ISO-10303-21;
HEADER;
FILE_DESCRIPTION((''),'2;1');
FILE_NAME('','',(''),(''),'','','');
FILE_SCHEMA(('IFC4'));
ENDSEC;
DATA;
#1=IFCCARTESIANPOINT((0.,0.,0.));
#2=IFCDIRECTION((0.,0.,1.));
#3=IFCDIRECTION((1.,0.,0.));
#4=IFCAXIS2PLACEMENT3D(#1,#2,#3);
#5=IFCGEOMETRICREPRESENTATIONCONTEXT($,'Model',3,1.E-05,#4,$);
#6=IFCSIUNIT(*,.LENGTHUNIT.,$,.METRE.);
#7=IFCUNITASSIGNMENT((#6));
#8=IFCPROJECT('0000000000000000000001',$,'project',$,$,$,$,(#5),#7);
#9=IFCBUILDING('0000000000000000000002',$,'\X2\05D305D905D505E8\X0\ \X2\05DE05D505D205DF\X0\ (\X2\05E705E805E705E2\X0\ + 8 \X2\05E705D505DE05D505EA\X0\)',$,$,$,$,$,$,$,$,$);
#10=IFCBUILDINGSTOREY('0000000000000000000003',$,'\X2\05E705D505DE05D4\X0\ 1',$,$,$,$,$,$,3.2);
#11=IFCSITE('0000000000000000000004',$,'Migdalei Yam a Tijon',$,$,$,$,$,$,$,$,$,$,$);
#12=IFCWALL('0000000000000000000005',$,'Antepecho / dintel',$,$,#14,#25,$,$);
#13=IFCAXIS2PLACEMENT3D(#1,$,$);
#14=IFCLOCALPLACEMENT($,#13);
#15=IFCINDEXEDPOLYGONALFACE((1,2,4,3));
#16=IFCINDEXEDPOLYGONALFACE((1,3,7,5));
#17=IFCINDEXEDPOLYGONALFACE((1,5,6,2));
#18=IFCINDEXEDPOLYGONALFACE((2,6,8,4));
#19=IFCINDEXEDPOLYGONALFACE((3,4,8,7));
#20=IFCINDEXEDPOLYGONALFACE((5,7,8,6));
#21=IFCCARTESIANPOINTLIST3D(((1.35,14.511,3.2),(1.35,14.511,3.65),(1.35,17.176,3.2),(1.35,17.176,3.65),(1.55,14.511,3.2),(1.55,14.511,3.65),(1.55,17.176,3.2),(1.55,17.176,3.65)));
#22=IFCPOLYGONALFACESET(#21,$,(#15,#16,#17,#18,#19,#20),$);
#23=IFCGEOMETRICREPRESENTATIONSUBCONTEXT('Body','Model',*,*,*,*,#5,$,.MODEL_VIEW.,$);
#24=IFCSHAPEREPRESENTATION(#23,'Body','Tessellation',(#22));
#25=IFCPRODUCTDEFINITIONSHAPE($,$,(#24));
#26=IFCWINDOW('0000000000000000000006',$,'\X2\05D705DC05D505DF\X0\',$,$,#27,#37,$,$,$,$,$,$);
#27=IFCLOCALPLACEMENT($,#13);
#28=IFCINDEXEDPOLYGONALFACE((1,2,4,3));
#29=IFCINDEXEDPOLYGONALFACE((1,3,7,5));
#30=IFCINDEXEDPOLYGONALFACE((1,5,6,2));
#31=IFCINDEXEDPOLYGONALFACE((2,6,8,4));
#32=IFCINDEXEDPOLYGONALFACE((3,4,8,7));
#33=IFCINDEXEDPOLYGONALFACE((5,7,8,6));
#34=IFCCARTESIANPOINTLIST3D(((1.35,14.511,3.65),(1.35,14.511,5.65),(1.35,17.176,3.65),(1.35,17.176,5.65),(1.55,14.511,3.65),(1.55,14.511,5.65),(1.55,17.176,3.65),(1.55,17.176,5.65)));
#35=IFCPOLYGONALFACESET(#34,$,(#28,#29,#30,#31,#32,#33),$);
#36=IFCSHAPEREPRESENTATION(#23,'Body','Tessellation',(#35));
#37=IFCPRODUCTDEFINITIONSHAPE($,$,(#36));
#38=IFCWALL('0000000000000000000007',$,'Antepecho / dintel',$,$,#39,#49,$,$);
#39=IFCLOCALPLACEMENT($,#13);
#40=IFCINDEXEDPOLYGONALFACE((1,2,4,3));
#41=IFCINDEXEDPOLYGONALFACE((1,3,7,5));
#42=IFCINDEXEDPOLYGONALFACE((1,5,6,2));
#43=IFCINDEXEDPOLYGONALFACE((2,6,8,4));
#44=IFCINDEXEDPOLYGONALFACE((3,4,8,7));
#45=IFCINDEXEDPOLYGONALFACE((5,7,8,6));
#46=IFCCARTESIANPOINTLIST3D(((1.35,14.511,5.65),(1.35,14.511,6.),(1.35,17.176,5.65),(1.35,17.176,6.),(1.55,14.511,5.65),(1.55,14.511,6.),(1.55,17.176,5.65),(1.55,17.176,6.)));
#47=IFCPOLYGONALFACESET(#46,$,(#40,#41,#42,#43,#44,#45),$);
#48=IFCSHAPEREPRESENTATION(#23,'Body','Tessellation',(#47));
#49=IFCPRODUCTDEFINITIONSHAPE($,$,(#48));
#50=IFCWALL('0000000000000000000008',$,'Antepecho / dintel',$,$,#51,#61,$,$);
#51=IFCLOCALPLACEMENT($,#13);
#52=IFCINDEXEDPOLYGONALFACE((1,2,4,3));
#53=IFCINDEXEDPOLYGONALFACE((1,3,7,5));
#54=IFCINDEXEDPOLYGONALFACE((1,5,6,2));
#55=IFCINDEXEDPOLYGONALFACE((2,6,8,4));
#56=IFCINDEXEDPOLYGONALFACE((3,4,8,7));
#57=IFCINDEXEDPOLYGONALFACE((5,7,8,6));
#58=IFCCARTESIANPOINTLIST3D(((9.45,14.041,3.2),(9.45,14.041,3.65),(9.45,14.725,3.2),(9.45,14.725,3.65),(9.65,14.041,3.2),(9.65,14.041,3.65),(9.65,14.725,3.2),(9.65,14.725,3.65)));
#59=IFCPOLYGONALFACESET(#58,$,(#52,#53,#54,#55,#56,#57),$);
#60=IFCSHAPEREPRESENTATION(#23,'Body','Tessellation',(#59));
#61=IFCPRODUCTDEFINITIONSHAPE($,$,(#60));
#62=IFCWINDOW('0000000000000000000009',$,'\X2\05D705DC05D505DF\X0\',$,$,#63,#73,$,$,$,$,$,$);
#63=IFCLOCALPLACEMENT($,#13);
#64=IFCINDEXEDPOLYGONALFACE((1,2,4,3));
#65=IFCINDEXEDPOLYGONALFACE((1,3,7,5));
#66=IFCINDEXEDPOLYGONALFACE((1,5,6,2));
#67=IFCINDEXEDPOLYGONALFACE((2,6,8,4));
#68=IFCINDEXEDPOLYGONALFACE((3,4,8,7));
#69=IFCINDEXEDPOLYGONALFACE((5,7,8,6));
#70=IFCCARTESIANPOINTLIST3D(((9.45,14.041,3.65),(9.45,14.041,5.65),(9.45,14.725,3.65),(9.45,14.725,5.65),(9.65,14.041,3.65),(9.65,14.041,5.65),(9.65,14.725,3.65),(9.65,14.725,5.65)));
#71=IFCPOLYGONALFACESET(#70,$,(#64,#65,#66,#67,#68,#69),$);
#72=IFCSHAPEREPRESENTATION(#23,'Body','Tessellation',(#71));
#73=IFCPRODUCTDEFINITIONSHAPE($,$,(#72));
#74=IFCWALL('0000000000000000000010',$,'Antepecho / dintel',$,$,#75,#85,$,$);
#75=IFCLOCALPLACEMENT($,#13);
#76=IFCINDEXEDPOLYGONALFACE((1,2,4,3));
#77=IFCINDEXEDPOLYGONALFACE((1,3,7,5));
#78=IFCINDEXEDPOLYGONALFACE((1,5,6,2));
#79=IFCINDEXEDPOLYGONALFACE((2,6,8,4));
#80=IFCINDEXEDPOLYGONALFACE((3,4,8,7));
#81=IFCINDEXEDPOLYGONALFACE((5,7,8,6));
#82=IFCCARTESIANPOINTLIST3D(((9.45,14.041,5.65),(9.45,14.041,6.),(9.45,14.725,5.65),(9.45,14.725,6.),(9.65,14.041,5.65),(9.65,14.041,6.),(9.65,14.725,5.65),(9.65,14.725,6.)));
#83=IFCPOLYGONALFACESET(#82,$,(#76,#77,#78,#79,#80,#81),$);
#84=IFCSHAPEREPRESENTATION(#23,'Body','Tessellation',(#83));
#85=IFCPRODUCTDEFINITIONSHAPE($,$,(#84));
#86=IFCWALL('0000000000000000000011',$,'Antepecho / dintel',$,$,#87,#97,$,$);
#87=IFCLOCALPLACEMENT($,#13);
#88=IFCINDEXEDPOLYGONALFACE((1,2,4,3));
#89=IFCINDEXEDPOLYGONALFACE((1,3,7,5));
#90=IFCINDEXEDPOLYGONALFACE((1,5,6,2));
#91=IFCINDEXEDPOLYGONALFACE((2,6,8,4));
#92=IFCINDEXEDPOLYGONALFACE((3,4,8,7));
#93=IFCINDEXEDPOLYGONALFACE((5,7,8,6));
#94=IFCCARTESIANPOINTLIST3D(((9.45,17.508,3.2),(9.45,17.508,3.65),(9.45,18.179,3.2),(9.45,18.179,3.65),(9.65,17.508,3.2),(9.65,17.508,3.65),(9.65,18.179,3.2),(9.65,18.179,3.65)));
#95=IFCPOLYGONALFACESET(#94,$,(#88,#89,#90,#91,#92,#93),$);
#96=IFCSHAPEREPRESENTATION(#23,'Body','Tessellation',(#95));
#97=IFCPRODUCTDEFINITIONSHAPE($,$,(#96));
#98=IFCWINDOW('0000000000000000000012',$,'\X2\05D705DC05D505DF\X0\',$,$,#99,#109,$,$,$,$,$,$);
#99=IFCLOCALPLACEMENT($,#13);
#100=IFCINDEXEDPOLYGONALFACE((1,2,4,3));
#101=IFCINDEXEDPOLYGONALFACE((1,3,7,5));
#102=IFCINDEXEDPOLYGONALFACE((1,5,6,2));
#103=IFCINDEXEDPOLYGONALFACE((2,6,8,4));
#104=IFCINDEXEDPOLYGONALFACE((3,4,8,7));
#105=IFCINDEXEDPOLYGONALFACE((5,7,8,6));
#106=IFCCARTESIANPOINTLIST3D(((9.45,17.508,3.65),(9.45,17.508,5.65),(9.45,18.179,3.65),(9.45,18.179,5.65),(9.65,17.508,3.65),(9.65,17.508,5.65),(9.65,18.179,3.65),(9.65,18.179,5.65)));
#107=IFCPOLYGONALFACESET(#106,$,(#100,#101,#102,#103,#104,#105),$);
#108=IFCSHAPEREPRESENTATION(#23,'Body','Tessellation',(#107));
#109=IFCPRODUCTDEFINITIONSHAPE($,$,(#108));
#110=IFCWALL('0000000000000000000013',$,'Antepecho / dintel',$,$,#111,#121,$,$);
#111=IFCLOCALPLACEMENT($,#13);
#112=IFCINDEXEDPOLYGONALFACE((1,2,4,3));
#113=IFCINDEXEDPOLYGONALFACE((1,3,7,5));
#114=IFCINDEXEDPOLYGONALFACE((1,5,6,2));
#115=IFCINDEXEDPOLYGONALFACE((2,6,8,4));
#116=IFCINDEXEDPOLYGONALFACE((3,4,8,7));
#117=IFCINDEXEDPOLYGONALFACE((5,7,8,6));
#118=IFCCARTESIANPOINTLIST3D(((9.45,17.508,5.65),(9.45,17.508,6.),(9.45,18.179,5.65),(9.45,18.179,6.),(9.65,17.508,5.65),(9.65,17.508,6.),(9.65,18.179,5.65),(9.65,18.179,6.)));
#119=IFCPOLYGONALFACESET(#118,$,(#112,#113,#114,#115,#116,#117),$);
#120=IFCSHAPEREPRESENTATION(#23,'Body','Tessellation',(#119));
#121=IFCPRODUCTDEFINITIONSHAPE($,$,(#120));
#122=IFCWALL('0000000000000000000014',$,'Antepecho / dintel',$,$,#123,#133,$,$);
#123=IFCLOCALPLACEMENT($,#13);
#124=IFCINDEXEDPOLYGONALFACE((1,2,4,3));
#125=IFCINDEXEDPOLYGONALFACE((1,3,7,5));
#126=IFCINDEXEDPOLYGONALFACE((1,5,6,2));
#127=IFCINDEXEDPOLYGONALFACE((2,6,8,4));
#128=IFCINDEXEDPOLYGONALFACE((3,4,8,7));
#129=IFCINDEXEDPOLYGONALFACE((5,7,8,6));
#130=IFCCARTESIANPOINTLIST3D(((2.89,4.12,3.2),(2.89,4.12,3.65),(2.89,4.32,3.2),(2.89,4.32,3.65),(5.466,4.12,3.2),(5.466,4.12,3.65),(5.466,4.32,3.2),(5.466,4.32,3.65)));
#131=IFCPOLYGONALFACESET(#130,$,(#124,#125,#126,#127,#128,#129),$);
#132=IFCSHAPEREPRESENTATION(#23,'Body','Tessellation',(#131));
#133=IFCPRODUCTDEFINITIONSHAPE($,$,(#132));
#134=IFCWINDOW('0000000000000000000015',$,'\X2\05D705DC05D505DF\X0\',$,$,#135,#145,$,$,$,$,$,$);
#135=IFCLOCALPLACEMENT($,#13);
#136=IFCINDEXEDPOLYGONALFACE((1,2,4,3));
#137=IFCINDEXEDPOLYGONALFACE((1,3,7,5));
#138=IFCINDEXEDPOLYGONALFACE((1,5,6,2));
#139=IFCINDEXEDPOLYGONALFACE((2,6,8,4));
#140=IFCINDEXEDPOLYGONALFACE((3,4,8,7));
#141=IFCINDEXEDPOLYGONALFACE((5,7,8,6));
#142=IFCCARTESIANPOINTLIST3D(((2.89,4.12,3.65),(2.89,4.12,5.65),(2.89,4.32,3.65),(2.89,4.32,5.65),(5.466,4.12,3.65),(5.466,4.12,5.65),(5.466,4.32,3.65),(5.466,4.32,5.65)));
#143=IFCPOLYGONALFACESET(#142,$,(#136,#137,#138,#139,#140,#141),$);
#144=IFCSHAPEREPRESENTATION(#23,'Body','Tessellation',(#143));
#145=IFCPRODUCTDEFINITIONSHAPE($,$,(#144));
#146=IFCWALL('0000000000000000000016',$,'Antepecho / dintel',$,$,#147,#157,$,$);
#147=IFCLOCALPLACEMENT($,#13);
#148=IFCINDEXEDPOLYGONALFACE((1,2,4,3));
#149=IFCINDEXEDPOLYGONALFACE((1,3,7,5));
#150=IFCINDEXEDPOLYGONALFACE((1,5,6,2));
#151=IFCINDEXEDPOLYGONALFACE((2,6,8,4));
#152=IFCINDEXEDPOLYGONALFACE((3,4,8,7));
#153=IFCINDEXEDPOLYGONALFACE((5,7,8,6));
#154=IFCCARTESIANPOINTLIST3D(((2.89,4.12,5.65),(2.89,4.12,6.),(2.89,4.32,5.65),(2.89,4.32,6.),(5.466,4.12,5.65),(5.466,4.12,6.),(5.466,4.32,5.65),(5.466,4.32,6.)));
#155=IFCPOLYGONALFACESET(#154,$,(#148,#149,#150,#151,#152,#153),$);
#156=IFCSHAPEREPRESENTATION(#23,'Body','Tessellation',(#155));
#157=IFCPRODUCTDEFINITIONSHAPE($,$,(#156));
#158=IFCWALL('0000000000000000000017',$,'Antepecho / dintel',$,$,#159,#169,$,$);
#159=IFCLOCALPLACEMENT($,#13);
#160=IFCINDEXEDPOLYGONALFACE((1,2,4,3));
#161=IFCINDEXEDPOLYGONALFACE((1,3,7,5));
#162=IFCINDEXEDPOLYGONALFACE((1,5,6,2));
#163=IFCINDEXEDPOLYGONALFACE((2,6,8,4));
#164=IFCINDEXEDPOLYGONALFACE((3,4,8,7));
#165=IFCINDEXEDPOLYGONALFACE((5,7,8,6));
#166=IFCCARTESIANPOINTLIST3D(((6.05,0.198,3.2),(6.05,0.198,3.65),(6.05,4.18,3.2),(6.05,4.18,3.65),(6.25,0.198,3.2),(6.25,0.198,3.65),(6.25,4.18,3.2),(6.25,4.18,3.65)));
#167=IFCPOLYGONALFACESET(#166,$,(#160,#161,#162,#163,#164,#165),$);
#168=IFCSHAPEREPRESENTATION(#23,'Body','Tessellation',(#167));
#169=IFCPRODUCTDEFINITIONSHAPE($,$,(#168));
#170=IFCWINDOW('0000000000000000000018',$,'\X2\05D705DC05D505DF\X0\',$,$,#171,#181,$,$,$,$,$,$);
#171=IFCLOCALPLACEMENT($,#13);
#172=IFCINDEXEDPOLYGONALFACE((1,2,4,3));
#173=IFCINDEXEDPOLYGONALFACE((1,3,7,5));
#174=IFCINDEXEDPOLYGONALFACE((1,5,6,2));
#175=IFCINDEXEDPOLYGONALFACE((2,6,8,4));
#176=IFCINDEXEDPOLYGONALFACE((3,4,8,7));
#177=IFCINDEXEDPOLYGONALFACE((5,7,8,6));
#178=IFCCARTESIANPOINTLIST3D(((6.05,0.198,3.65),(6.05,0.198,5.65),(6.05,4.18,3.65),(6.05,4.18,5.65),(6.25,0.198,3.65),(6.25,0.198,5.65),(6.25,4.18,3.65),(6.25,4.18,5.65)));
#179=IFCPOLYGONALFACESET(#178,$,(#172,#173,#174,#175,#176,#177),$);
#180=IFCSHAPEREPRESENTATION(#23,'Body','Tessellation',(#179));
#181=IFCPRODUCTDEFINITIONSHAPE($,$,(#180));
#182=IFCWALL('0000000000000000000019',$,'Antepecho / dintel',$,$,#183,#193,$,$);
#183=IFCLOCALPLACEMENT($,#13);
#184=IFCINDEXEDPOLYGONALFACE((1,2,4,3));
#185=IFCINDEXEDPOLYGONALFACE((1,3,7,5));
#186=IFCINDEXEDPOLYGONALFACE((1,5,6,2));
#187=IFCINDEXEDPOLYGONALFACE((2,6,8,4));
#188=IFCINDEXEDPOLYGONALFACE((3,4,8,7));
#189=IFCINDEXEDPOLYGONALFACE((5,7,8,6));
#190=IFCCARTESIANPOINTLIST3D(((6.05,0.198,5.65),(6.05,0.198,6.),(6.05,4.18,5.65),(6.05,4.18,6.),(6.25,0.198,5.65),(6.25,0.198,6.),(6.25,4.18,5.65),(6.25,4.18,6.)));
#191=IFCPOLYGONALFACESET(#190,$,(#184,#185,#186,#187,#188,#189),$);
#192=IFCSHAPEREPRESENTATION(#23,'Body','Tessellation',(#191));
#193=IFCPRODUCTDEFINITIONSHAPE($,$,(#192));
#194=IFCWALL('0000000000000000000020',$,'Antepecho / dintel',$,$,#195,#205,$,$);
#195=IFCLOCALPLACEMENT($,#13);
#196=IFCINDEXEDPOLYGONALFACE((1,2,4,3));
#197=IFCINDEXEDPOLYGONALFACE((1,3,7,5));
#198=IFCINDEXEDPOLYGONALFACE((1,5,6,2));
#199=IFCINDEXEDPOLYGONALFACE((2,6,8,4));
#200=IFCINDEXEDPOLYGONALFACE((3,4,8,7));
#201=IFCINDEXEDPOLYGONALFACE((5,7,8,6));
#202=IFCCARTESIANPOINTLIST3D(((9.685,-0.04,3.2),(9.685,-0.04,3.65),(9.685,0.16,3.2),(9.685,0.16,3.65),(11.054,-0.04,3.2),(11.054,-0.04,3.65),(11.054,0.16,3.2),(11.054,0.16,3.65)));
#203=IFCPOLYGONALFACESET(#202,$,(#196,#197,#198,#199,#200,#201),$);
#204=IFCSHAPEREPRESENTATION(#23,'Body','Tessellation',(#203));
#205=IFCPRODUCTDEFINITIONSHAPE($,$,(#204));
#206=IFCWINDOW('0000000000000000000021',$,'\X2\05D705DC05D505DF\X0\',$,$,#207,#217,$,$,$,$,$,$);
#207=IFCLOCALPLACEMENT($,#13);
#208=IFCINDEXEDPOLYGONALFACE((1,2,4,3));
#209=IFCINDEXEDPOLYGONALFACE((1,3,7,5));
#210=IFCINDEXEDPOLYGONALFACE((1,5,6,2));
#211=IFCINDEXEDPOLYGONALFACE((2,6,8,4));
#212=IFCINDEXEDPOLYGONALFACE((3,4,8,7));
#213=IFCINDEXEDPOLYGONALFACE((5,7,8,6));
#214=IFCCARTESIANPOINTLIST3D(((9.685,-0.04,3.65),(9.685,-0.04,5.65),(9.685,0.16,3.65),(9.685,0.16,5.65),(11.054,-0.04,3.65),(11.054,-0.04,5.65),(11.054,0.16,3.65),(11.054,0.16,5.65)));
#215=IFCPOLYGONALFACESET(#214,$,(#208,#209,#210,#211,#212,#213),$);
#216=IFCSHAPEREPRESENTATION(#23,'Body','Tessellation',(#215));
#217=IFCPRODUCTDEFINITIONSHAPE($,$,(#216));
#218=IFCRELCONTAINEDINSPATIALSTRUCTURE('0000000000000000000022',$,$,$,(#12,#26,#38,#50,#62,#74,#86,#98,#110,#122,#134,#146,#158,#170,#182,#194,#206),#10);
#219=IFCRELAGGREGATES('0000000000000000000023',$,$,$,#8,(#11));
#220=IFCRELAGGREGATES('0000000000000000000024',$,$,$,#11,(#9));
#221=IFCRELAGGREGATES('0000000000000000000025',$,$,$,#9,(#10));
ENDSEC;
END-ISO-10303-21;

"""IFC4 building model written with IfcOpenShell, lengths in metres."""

from ifc_helpers import new_model, si_unit, frame, origin_with_axes, context, subcontext, project, spatial, line, indexed_curve, outline, extrude, element, save


model = new_model("IFC4")

# Units and contexts
model_context = context("Model", 3, precision=1e-05, world=origin_with_axes())
body_context = subcontext(model_context, "Body", "Model", "MODEL_VIEW")
ifc_project = project(units=[si_unit("LENGTHUNIT", "METRE")], contexts=[model_context])

# Site, building, storey
site = spatial("IfcSite", under=ifc_project, Name="Migdalei Yam a Tijon")
building = spatial("IfcBuilding", under=site, Name="דיור מוגן (קרקע + 8 קומות)")
storey = spatial("IfcBuildingStorey", under=building, Name="קומה 1", Elevation=3.2)

# Wall
element("IfcWall", 1, inside=storey, Name="Antepecho / dintel", context=body_context, shape_type="SweptSolid", body=[
    extrude(outline(indexed_curve([(0.0, 0.0), (0.2, 0.0), (0.2, 2.665), (0.0, 2.665)], segments=[line(1, 2, 3, 4, 1)])), frame((1.35, 14.511, 3.2), z_axis=(0.0, 0.0, 1.0), x_axis=(1.0, 0.0, 0.0)), (0.0, 0.0, 1.0), 0.45),
])

# Window
element("IfcWindow", 2, inside=storey, Name="חלון", context=body_context, shape_type="SweptSolid", body=[
    extrude(outline(indexed_curve([(0.0, 0.0), (0.2, 0.0), (0.2, 2.665), (0.0, 2.665)], segments=[line(1, 2, 3, 4, 1)])), frame((1.35, 14.511, 3.65), z_axis=(0.0, 0.0, 1.0), x_axis=(1.0, 0.0, 0.0)), (0.0, 0.0, 1.0), 2.0),
])

# Walls
element("IfcWall", 3, inside=storey, Name="Antepecho / dintel", context=body_context, shape_type="SweptSolid", body=[
    extrude(outline(indexed_curve([(0.0, 0.0), (0.2, 0.0), (0.2, 2.665), (0.0, 2.665)], segments=[line(1, 2, 3, 4, 1)])), frame((1.35, 14.511, 5.65), z_axis=(0.0, 0.0, 1.0), x_axis=(1.0, 0.0, 0.0)), (0.0, 0.0, 1.0), 0.35),
])
element("IfcWall", 4, inside=storey, Name="Antepecho / dintel", context=body_context, shape_type="SweptSolid", body=[
    extrude(outline(indexed_curve([(0.0, 0.0), (0.2, 0.0), (0.2, 0.684), (0.0, 0.684)], segments=[line(1, 2, 3, 4, 1)])), frame((9.45, 14.041, 3.2), z_axis=(0.0, 0.0, 1.0), x_axis=(1.0, 0.0, 0.0)), (0.0, 0.0, 1.0), 0.45),
])

# Window
element("IfcWindow", 5, inside=storey, Name="חלון", context=body_context, shape_type="SweptSolid", body=[
    extrude(outline(indexed_curve([(0.0, 0.0), (0.2, 0.0), (0.2, 0.684), (0.0, 0.684)], segments=[line(1, 2, 3, 4, 1)])), frame((9.45, 14.041, 3.65), z_axis=(0.0, 0.0, 1.0), x_axis=(1.0, 0.0, 0.0)), (0.0, 0.0, 1.0), 2.0),
])

# Walls
element("IfcWall", 6, inside=storey, Name="Antepecho / dintel", context=body_context, shape_type="SweptSolid", body=[
    extrude(outline(indexed_curve([(0.0, 0.0), (0.2, 0.0), (0.2, 0.684), (0.0, 0.684)], segments=[line(1, 2, 3, 4, 1)])), frame((9.45, 14.041, 5.65), z_axis=(0.0, 0.0, 1.0), x_axis=(1.0, 0.0, 0.0)), (0.0, 0.0, 1.0), 0.35),
])
element("IfcWall", 7, inside=storey, Name="Antepecho / dintel", context=body_context, shape_type="SweptSolid", body=[
    extrude(outline(indexed_curve([(0.0, 0.0), (0.2, 0.0), (0.2, 0.671), (0.0, 0.671)], segments=[line(1, 2, 3, 4, 1)])), frame((9.45, 17.508, 3.2), z_axis=(0.0, 0.0, 1.0), x_axis=(1.0, 0.0, 0.0)), (0.0, 0.0, 1.0), 0.45),
])

# Window
element("IfcWindow", 8, inside=storey, Name="חלון", context=body_context, shape_type="SweptSolid", body=[
    extrude(outline(indexed_curve([(0.0, 0.0), (0.2, 0.0), (0.2, 0.671), (0.0, 0.671)], segments=[line(1, 2, 3, 4, 1)])), frame((9.45, 17.508, 3.65), z_axis=(0.0, 0.0, 1.0), x_axis=(1.0, 0.0, 0.0)), (0.0, 0.0, 1.0), 2.0),
])

# Walls
element("IfcWall", 9, inside=storey, Name="Antepecho / dintel", context=body_context, shape_type="SweptSolid", body=[
    extrude(outline(indexed_curve([(0.0, 0.0), (0.2, 0.0), (0.2, 0.671), (0.0, 0.671)], segments=[line(1, 2, 3, 4, 1)])), frame((9.45, 17.508, 5.65), z_axis=(0.0, 0.0, 1.0), x_axis=(1.0, 0.0, 0.0)), (0.0, 0.0, 1.0), 0.35),
])
element("IfcWall", 10, inside=storey, Name="Antepecho / dintel", context=body_context, shape_type="SweptSolid", body=[
    extrude(outline(indexed_curve([(0.0, 0.0), (2.576, 0.0), (2.576, 0.2), (0.0, 0.2)], segments=[line(1, 2, 3, 4, 1)])), frame((2.89, 4.12, 3.2), z_axis=(0.0, 0.0, 1.0), x_axis=(1.0, 0.0, 0.0)), (0.0, 0.0, 1.0), 0.45),
])

# Window
element("IfcWindow", 11, inside=storey, Name="חלון", context=body_context, shape_type="SweptSolid", body=[
    extrude(outline(indexed_curve([(0.0, 0.0), (2.576, 0.0), (2.576, 0.2), (0.0, 0.2)], segments=[line(1, 2, 3, 4, 1)])), frame((2.89, 4.12, 3.65), z_axis=(0.0, 0.0, 1.0), x_axis=(1.0, 0.0, 0.0)), (0.0, 0.0, 1.0), 2.0),
])

# Walls
element("IfcWall", 12, inside=storey, Name="Antepecho / dintel", context=body_context, shape_type="SweptSolid", body=[
    extrude(outline(indexed_curve([(0.0, 0.0), (2.576, 0.0), (2.576, 0.2), (0.0, 0.2)], segments=[line(1, 2, 3, 4, 1)])), frame((2.89, 4.12, 5.65), z_axis=(0.0, 0.0, 1.0), x_axis=(1.0, 0.0, 0.0)), (0.0, 0.0, 1.0), 0.35),
])
element("IfcWall", 13, inside=storey, Name="Antepecho / dintel", context=body_context, shape_type="SweptSolid", body=[
    extrude(outline(indexed_curve([(0.0, 0.0), (0.2, 0.0), (0.2, 3.982), (0.0, 3.982)], segments=[line(1, 2, 3, 4, 1)])), frame((6.05, 0.198, 3.2), z_axis=(0.0, 0.0, 1.0), x_axis=(1.0, 0.0, 0.0)), (0.0, 0.0, 1.0), 0.45),
])

# Window
element("IfcWindow", 14, inside=storey, Name="חלון", context=body_context, shape_type="SweptSolid", body=[
    extrude(outline(indexed_curve([(0.0, 0.0), (0.2, 0.0), (0.2, 3.982), (0.0, 3.982)], segments=[line(1, 2, 3, 4, 1)])), frame((6.05, 0.198, 3.65), z_axis=(0.0, 0.0, 1.0), x_axis=(1.0, 0.0, 0.0)), (0.0, 0.0, 1.0), 2.0),
])

# Walls
element("IfcWall", 15, inside=storey, Name="Antepecho / dintel", context=body_context, shape_type="SweptSolid", body=[
    extrude(outline(indexed_curve([(0.0, 0.0), (0.2, 0.0), (0.2, 3.982), (0.0, 3.982)], segments=[line(1, 2, 3, 4, 1)])), frame((6.05, 0.198, 5.65), z_axis=(0.0, 0.0, 1.0), x_axis=(1.0, 0.0, 0.0)), (0.0, 0.0, 1.0), 0.35),
])
element("IfcWall", 16, inside=storey, Name="Antepecho / dintel", context=body_context, shape_type="SweptSolid", body=[
    extrude(outline(indexed_curve([(0.0, 0.0), (1.369, 0.0), (1.369, 0.2), (0.0, 0.2)], segments=[line(1, 2, 3, 4, 1)])), frame((9.685, -0.04, 3.2), z_axis=(0.0, 0.0, 1.0), x_axis=(1.0, 0.0, 0.0)), (0.0, 0.0, 1.0), 0.45),
])

# Window
element("IfcWindow", 17, inside=storey, Name="חלון", context=body_context, shape_type="SweptSolid", body=[
    extrude(outline(indexed_curve([(0.0, 0.0), (1.369, 0.0), (1.369, 0.2), (0.0, 0.2)], segments=[line(1, 2, 3, 4, 1)])), frame((9.685, -0.04, 3.65), z_axis=(0.0, 0.0, 1.0), x_axis=(1.0, 0.0, 0.0)), (0.0, 0.0, 1.0), 2.0),
])

save(model, "model.ifc")
